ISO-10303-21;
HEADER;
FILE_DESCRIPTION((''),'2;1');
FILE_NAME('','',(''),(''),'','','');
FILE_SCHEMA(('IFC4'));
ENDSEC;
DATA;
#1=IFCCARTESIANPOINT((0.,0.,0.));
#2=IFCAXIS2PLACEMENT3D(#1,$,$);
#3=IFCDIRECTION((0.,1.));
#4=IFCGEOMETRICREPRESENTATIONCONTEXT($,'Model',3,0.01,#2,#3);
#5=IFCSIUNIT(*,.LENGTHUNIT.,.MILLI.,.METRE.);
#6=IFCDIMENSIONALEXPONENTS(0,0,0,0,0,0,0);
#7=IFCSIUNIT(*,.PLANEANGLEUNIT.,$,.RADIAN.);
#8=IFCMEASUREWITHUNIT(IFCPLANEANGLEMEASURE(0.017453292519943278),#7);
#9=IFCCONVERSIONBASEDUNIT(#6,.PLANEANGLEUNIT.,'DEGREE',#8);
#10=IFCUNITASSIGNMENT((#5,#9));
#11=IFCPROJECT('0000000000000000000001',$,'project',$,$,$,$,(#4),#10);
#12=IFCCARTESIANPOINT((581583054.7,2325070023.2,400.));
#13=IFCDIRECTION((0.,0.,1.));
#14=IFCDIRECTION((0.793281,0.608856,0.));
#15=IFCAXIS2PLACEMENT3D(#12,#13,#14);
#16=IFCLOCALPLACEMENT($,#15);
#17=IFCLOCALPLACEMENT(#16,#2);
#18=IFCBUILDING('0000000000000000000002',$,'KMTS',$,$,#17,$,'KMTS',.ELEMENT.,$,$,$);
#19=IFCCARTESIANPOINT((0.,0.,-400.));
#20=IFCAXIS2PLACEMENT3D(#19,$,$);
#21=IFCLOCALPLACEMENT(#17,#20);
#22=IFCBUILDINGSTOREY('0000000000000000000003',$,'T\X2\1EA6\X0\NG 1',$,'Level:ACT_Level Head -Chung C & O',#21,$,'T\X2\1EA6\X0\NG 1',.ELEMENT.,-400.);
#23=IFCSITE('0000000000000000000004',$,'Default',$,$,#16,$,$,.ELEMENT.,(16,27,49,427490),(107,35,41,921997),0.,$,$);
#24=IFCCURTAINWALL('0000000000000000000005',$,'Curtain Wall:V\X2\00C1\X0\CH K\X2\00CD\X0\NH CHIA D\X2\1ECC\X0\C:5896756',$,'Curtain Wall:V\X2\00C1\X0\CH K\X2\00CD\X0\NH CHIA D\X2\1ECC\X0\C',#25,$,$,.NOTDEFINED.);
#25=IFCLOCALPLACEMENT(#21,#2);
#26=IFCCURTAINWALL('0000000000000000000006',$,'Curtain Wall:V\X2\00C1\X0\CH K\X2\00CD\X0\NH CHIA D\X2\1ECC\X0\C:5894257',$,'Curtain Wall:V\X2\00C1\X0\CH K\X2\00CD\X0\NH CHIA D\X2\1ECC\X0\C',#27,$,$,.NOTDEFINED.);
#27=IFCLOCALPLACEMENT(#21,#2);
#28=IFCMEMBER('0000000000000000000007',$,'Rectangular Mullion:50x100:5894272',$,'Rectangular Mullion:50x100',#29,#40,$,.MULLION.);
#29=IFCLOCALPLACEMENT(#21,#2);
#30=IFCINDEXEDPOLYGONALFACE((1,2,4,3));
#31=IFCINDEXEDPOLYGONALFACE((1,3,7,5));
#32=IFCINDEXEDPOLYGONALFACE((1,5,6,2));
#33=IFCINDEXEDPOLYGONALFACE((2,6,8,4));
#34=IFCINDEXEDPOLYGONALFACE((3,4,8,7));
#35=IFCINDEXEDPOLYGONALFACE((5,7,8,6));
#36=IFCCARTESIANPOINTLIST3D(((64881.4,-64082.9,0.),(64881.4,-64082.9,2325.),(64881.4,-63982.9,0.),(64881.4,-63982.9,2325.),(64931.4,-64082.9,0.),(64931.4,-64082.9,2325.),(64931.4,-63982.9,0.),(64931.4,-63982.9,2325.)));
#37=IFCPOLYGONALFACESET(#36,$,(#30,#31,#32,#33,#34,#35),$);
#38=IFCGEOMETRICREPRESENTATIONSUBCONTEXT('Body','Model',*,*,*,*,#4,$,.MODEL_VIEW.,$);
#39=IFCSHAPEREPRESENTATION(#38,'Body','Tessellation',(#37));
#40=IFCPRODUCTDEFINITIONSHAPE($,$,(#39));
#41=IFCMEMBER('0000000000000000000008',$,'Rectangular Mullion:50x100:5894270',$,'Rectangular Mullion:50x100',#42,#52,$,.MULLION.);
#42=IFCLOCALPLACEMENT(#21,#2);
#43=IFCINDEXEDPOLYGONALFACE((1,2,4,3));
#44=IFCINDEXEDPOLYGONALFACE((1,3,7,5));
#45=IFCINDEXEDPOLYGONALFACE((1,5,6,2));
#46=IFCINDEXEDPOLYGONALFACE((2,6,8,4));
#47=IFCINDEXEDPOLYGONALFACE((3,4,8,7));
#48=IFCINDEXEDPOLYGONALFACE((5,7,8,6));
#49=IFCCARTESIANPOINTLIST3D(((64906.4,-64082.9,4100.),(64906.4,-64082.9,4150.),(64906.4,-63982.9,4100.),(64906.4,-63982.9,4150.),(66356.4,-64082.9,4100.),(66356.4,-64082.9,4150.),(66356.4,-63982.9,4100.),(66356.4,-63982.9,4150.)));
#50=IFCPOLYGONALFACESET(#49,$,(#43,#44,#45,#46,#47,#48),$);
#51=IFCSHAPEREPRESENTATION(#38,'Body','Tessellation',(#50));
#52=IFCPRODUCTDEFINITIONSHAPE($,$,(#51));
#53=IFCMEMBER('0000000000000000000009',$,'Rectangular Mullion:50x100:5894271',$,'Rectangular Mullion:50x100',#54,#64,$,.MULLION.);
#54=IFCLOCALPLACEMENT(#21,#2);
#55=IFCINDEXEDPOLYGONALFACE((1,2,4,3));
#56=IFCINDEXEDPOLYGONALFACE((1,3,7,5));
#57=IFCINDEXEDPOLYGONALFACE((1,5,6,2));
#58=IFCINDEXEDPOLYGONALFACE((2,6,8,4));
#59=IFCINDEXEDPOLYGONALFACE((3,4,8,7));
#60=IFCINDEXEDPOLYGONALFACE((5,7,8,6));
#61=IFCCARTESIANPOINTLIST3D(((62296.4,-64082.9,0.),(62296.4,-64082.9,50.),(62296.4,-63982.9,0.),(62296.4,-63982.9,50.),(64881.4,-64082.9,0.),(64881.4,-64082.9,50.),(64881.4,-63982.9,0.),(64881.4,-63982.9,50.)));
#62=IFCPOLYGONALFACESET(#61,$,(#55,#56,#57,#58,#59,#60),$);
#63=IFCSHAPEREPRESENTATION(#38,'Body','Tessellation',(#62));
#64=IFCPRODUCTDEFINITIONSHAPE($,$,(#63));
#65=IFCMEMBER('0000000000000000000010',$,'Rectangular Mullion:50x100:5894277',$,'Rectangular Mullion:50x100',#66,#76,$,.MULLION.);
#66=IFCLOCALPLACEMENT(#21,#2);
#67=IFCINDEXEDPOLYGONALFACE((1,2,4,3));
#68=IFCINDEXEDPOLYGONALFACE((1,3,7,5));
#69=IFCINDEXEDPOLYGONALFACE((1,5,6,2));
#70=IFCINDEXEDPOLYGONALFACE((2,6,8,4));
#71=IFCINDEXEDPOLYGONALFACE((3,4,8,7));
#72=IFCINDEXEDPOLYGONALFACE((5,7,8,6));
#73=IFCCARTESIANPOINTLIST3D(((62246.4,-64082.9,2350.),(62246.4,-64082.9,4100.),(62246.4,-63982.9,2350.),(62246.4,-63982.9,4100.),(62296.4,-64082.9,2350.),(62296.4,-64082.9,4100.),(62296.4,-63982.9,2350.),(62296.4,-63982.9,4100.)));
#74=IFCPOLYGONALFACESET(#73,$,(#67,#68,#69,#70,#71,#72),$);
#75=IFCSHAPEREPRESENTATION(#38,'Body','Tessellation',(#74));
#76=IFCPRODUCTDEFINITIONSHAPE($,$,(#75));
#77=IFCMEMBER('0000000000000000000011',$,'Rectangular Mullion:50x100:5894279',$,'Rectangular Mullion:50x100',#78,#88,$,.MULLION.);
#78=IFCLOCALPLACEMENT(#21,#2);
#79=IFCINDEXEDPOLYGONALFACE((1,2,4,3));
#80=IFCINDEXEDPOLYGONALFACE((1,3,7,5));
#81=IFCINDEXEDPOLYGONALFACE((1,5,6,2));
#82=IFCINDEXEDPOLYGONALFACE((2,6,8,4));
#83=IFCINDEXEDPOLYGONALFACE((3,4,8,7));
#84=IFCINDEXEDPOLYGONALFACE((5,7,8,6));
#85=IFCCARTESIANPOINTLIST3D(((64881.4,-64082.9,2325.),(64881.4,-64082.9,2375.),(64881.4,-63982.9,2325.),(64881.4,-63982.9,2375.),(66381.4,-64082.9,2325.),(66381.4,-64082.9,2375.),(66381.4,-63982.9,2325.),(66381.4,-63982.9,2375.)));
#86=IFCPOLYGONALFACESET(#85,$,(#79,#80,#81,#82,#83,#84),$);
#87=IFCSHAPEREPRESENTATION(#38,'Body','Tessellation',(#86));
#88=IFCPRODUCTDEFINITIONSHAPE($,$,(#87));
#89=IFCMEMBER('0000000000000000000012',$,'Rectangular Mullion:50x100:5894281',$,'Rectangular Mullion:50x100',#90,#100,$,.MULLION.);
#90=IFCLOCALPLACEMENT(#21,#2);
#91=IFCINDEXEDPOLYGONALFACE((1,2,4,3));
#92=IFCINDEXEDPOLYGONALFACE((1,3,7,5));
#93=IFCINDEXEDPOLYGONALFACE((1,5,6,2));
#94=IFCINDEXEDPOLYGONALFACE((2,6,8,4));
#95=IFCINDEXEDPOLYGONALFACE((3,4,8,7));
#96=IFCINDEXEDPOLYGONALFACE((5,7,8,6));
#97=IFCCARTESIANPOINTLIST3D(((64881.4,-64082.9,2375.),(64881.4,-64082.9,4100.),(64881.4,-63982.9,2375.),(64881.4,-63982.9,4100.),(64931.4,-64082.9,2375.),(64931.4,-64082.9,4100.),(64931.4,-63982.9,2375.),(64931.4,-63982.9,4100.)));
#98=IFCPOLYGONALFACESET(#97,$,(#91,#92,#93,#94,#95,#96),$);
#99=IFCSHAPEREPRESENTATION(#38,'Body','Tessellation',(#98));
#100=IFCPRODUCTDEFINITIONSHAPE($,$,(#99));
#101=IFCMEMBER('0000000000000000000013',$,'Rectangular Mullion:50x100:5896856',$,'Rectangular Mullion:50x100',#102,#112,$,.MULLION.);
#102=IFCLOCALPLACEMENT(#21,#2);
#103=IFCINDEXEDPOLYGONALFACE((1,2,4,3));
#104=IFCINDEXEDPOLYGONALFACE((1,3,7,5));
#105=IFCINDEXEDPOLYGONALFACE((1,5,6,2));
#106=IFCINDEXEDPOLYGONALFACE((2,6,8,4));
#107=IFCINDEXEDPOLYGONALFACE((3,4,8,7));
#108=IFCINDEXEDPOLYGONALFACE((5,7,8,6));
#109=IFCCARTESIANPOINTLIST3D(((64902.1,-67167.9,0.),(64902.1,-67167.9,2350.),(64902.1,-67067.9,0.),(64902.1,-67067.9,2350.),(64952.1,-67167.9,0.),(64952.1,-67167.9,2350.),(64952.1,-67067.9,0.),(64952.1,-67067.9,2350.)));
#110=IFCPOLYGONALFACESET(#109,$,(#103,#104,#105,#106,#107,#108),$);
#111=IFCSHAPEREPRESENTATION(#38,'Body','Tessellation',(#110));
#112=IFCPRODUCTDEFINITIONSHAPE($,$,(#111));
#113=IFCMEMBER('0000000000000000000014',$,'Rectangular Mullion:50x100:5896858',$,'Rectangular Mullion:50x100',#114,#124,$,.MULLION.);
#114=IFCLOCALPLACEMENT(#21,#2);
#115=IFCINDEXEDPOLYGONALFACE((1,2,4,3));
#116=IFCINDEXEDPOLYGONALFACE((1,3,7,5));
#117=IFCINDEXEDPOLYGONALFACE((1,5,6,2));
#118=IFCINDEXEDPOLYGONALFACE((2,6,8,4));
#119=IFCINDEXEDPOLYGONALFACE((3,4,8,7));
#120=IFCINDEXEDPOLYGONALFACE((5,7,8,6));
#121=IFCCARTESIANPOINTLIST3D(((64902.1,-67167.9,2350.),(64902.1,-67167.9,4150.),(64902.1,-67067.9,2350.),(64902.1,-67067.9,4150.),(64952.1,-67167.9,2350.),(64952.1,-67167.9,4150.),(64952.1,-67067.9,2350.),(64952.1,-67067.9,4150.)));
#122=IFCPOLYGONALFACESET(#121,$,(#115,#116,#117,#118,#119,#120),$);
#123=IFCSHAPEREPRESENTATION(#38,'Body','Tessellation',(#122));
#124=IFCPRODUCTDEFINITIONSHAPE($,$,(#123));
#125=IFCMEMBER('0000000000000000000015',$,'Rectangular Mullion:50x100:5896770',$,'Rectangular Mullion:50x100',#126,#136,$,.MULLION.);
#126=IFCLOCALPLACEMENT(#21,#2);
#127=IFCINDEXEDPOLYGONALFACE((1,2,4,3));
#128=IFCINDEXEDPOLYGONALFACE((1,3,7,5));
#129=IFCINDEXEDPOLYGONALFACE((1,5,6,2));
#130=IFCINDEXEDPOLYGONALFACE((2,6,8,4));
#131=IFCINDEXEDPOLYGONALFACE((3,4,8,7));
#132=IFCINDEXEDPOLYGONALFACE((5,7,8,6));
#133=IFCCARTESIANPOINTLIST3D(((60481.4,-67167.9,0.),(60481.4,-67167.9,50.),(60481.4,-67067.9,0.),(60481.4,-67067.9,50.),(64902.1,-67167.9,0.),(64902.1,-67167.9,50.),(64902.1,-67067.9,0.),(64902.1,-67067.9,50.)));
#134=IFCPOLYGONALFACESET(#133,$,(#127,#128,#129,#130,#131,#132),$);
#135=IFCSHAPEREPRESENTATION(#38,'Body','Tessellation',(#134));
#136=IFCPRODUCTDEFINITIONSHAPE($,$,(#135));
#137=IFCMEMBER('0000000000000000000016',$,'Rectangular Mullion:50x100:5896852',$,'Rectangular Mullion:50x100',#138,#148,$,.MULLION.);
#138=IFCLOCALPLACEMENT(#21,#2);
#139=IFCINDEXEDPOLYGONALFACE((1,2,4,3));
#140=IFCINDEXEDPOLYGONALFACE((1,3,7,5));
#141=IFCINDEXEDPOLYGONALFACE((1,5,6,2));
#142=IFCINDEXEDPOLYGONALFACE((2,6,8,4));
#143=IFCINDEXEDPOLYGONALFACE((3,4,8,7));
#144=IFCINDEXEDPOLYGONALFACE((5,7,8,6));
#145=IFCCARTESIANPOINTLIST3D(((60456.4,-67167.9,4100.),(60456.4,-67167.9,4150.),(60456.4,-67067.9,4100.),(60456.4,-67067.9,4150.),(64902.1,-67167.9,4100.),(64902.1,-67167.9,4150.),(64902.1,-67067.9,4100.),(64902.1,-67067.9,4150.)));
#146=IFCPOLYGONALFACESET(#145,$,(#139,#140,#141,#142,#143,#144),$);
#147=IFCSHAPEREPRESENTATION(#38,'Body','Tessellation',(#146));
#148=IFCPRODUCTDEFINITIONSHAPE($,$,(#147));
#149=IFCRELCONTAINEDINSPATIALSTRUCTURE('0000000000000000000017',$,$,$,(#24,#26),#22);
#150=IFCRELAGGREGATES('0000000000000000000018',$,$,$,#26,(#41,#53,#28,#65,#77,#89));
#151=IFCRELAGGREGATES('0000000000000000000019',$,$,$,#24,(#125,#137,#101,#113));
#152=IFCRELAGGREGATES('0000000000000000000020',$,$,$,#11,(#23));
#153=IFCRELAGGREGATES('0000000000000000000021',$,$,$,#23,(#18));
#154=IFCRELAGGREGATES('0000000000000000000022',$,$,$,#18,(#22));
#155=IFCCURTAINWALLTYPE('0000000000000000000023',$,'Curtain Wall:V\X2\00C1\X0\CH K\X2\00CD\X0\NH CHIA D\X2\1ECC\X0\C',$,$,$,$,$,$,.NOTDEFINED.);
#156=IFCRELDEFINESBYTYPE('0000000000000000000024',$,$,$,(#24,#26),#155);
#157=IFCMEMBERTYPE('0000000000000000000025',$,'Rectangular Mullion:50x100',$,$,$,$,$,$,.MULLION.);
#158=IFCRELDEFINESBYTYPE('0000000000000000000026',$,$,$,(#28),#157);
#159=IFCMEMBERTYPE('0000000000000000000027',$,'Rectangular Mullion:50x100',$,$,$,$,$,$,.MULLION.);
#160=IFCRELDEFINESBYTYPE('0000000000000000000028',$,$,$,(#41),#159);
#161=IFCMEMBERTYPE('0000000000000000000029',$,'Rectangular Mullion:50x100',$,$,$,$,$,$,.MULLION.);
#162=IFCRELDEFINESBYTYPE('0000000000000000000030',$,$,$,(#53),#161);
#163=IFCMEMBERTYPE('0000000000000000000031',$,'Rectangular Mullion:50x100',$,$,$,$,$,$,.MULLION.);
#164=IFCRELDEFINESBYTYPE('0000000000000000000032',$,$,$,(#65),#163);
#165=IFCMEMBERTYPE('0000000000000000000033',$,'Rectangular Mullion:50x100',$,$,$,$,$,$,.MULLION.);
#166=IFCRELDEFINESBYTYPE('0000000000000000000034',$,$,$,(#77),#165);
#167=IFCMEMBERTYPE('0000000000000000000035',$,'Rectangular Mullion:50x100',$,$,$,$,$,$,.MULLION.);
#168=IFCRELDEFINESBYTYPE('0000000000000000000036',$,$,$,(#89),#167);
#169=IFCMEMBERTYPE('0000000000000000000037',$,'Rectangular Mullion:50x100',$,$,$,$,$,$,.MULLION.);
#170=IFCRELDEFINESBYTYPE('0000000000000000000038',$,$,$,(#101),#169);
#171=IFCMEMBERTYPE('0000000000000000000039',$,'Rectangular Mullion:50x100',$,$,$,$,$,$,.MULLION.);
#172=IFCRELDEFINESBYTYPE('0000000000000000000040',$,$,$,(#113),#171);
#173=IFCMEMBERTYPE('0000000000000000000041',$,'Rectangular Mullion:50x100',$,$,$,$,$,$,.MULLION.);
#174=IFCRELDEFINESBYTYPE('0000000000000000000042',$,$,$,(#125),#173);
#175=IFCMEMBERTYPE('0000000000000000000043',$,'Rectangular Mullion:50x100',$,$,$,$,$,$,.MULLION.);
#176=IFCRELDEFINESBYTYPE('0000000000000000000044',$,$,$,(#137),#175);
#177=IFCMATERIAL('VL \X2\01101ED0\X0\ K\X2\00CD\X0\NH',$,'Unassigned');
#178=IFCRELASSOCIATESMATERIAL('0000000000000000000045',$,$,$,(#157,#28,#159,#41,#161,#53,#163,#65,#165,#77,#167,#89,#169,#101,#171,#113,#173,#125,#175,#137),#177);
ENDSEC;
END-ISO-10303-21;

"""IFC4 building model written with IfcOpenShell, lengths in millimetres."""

from ifc_helpers import new_model, entity, si_unit, converted_unit, direction, frame, origin, place, context, subcontext, project, spatial, indexed_curve, outline, extrude, source, transform, mapped, material, type_object, type_shapes, element, aggregate, save


model = new_model("IFC4")

# Units and contexts
model_context = context("Model", 3, precision=0.01, world=origin(), true_north=direction((0.0, 1.0)))
body_context = subcontext(model_context, "Body", "Model", "MODEL_VIEW")
ifc_project = project(units=[si_unit("LENGTHUNIT", "METRE", prefix="MILLI"), converted_unit("PLANEANGLEUNIT", "DEGREE", entity("IfcPlaneAngleMeasure", 0.017453292519943278), si_unit("PLANEANGLEUNIT", "RADIAN"), dimensions=[0, 0, 0, 0, 0, 0, 0])], contexts=[model_context])

# Site, building, storey
site_placement = place(None, frame((581583054.7, 2325070023.2, 400.0), z_axis=(0.0, 0.0, 1.0), x_axis=(0.793281, 0.608856, 0.0)))
site = spatial("IfcSite", under=ifc_project, at=site_placement, Name="Default", CompositionType="ELEMENT", RefLatitude=(16, 27, 49, 427490), RefLongitude=(107, 35, 41, 921997), RefElevation=0.0)
building_placement = place(site_placement, origin())
building = spatial("IfcBuilding", under=site, at=building_placement, Name="KMTS", LongName="KMTS", CompositionType="ELEMENT")
storey_placement = place(building_placement, frame((0.0, 0.0, -400.0)))
storey = spatial("IfcBuildingStorey", under=building, at=storey_placement, Name="TẦNG 1", ObjectType="Level:ACT_Level Head -Chung C & O", LongName="TẦNG 1", CompositionType="ELEMENT", Elevation=-400.0)

# Curtain walls, members
curtain_wall_type = type_object("IfcCurtainWallType", Name="Curtain Wall:VÁCH KÍNH CHIA DỌC", PredefinedType="NOTDEFINED")
curtain_wall_1_placement = place(storey_placement, frame((0.0, 0.0, 400.0)))
curtain_wall_1 = element("IfcCurtainWall", 1, at=curtain_wall_1_placement, inside=storey, type_object=curtain_wall_type, Name="Curtain Wall:VÁCH KÍNH CHIA DỌC:5896756", ObjectType="Curtain Wall:VÁCH KÍNH CHIA DỌC", PredefinedType="NOTDEFINED")
ifc_material_1 = material(Name="VL ĐỐ KÍNH", Category="Unassigned")
curtain_wall_2_placement = place(storey_placement, frame((0.0, 0.0, 400.0)))
curtain_wall_2 = element("IfcCurtainWall", 2, at=curtain_wall_2_placement, inside=storey, type_object=curtain_wall_type, Name="Curtain Wall:VÁCH KÍNH CHIA DỌC:5894257", ObjectType="Curtain Wall:VÁCH KÍNH CHIA DỌC", PredefinedType="NOTDEFINED")
member_type_1 = type_object("IfcMemberType", Name="Rectangular Mullion:50x100", PredefinedType="MULLION", material=ifc_material_1)
shared_shape_1 = source(origin(), body_context, "Body", "SweptSolid", [
    extrude(outline(indexed_curve([(-25.0, -50.0), (25.0, -50.0), (25.0, 50.0), (-25.0, 50.0), (-25.0, -50.0)], self_intersect=False)), frame((0.0, 0.0, -2325.0), z_axis=(0.0, 0.0, 1.0), x_axis=(-1.0, 0.0, 0.0)), (0.0, 0.0, 1.0), 2325.0),
])
type_shapes(member_type_1, [shared_shape_1])
member_1_placement = place(curtain_wall_2_placement, frame((64906.4, -64032.9, -400.0), z_axis=(0.0, 0.0, -1.0), x_axis=(-1.0, 0.0, 0.0)))
member_1 = element("IfcMember", 3, at=member_1_placement, type_object=member_type_1, material=ifc_material_1, Name="Rectangular Mullion:50x100:5894272", ObjectType="Rectangular Mullion:50x100", PredefinedType="MULLION", context=body_context, shape_type="MappedRepresentation", body=[
    mapped(shared_shape_1, transform((0.0, 0.0, 0.0), scale=1.0)),
])
member_type_2 = type_object("IfcMemberType", Name="Rectangular Mullion:50x100", PredefinedType="MULLION", material=ifc_material_1)
shared_shape_2 = source(origin(), body_context, "Body", "SweptSolid", [
    extrude(outline(indexed_curve([(-25.0, -50.0), (25.0, -50.0), (25.0, 50.0), (-25.0, 50.0), (-25.0, -50.0)], self_intersect=False)), frame((-25.0, 0.0, -1450.0), z_axis=(0.0, 0.0, 1.0), x_axis=(-1.0, 0.0, 0.0)), (0.0, 0.0, 1.0), 1450.0),
])
type_shapes(member_type_2, [shared_shape_2])
member_2_placement = place(curtain_wall_2_placement, frame((64906.4, -64032.9, 3750.0), z_axis=(-1.0, 0.0, 0.0), x_axis=(0.0, 0.0, 1.0)))
member_2 = element("IfcMember", 4, at=member_2_placement, type_object=member_type_2, material=ifc_material_1, Name="Rectangular Mullion:50x100:5894270", ObjectType="Rectangular Mullion:50x100", PredefinedType="MULLION", context=body_context, shape_type="MappedRepresentation", body=[
    mapped(shared_shape_2, transform((0.0, 0.0, 0.0), scale=1.0)),
])
member_type_3 = type_object("IfcMemberType", Name="Rectangular Mullion:50x100", PredefinedType="MULLION", material=ifc_material_1)
shared_shape_3 = source(origin(), body_context, "Body", "SweptSolid", [
    extrude(outline(indexed_curve([(-25.0, -50.0), (25.0, -50.0), (25.0, 50.0), (-25.0, 50.0), (-25.0, -50.0)], self_intersect=False)), frame((-25.0, 0.0, -2585.0), z_axis=(0.0, 0.0, 1.0), x_axis=(-1.0, 0.0, 0.0)), (0.0, 0.0, 1.0), 2585.0),
])
type_shapes(member_type_3, [shared_shape_3])
member_3_placement = place(curtain_wall_2_placement, frame((64881.4, -64032.9, -400.0), z_axis=(1.0, 0.0, 0.0), x_axis=(0.0, 0.0, -1.0)))
member_3 = element("IfcMember", 5, at=member_3_placement, type_object=member_type_3, material=ifc_material_1, Name="Rectangular Mullion:50x100:5894271", ObjectType="Rectangular Mullion:50x100", PredefinedType="MULLION", context=body_context, shape_type="MappedRepresentation", body=[
    mapped(shared_shape_3, transform((0.0, 0.0, 0.0), scale=1.0)),
])
member_type_4 = type_object("IfcMemberType", Name="Rectangular Mullion:50x100", PredefinedType="MULLION", material=ifc_material_1)
shared_shape_4 = source(origin(), body_context, "Body", "SweptSolid", [
    extrude(outline(indexed_curve([(-25.0, -50.0), (25.0, -50.0), (25.0, 50.0), (-25.0, 50.0), (-25.0, -50.0)], self_intersect=False)), frame((-25.0, 0.0, -1750.0), z_axis=(0.0, 0.0, 1.0), x_axis=(-1.0, 0.0, 0.0)), (0.0, 0.0, 1.0), 1750.0),
])
type_shapes(member_type_4, [shared_shape_4])
member_4_placement = place(curtain_wall_2_placement, frame((62246.4, -64032.9, 1950.0), z_axis=(0.0, 0.0, -1.0), x_axis=(-1.0, 0.0, 0.0)))
member_4 = element("IfcMember", 6, at=member_4_placement, type_object=member_type_4, material=ifc_material_1, Name="Rectangular Mullion:50x100:5894277", ObjectType="Rectangular Mullion:50x100", PredefinedType="MULLION", context=body_context, shape_type="MappedRepresentation", body=[
    mapped(shared_shape_4, transform((0.0, 0.0, 0.0), scale=1.0)),
])
member_type_5 = type_object("IfcMemberType", Name="Rectangular Mullion:50x100", PredefinedType="MULLION", material=ifc_material_1)
shared_shape_5 = source(origin(), body_context, "Body", "SweptSolid", [
    extrude(outline(indexed_curve([(-25.0, -50.0), (25.0, -50.0), (25.0, 50.0), (-25.0, 50.0), (-25.0, -50.0)], self_intersect=False)), frame((0.0, 0.0, -1500.0), z_axis=(0.0, 0.0, 1.0), x_axis=(-1.0, 0.0, 0.0)), (0.0, 0.0, 1.0), 1500.0),
])
type_shapes(member_type_5, [shared_shape_5])
member_5_placement = place(curtain_wall_2_placement, frame((64881.4, -64032.9, 1950.0), z_axis=(-1.0, 0.0, 0.0), x_axis=(0.0, 0.0, 1.0)))
member_5 = element("IfcMember", 7, at=member_5_placement, type_object=member_type_5, material=ifc_material_1, Name="Rectangular Mullion:50x100:5894279", ObjectType="Rectangular Mullion:50x100", PredefinedType="MULLION", context=body_context, shape_type="MappedRepresentation", body=[
    mapped(shared_shape_5, transform((0.0, 0.0, 0.0), scale=1.0)),
])
member_type_6 = type_object("IfcMemberType", Name="Rectangular Mullion:50x100", PredefinedType="MULLION", material=ifc_material_1)
shared_shape_6 = source(origin(), body_context, "Body", "SweptSolid", [
    extrude(outline(indexed_curve([(-25.0, -50.0), (25.0, -50.0), (25.0, 50.0), (-25.0, 50.0), (-25.0, -50.0)], self_intersect=False)), frame((0.0, 0.0, -1725.0), z_axis=(0.0, 0.0, 1.0), x_axis=(-1.0, 0.0, 0.0)), (0.0, 0.0, 1.0), 1725.0),
])
type_shapes(member_type_6, [shared_shape_6])
member_6_placement = place(curtain_wall_2_placement, frame((64906.4, -64032.9, 1975.0), z_axis=(0.0, 0.0, -1.0), x_axis=(-1.0, 0.0, 0.0)))
member_6 = element("IfcMember", 8, at=member_6_placement, type_object=member_type_6, material=ifc_material_1, Name="Rectangular Mullion:50x100:5894281", ObjectType="Rectangular Mullion:50x100", PredefinedType="MULLION", context=body_context, shape_type="MappedRepresentation", body=[
    mapped(shared_shape_6, transform((0.0, 0.0, 0.0), scale=1.0)),
])

# Members
member_type_7 = type_object("IfcMemberType", Name="Rectangular Mullion:50x100", PredefinedType="MULLION", material=ifc_material_1)
shared_shape_7 = source(origin(), body_context, "Body", "SweptSolid", [
    extrude(outline(indexed_curve([(-25.0, -50.0), (25.0, -50.0), (25.0, 50.0), (-25.0, 50.0), (-25.0, -50.0)], self_intersect=False)), frame((0.0, 0.0, -2350.0), z_axis=(0.0, 0.0, 1.0), x_axis=(-1.0, 0.0, 0.0)), (0.0, 0.0, 1.0), 2350.0),
])
type_shapes(member_type_7, [shared_shape_7])
member_7_placement = place(curtain_wall_1_placement, frame((64927.1, -67117.9, -400.0), z_axis=(0.0, 0.0, -1.0), x_axis=(1.0, 0.0, 0.0)))
member_7 = element("IfcMember", 9, at=member_7_placement, type_object=member_type_7, material=ifc_material_1, Name="Rectangular Mullion:50x100:5896856", ObjectType="Rectangular Mullion:50x100", PredefinedType="MULLION", context=body_context, shape_type="MappedRepresentation", body=[
    mapped(shared_shape_7, transform((0.0, 0.0, 0.0), scale=1.0)),
])
member_type_8 = type_object("IfcMemberType", Name="Rectangular Mullion:50x100", PredefinedType="MULLION", material=ifc_material_1)
shared_shape_8 = source(origin(), body_context, "Body", "SweptSolid", [
    extrude(outline(indexed_curve([(-25.0, -50.0), (25.0, -50.0), (25.0, 50.0), (-25.0, 50.0), (-25.0, -50.0)], self_intersect=False)), frame((0.0, 0.0, -1800.0), z_axis=(0.0, 0.0, 1.0), x_axis=(-1.0, 0.0, 0.0)), (0.0, 0.0, 1.0), 1800.0),
])
type_shapes(member_type_8, [shared_shape_8])
member_8_placement = place(curtain_wall_1_placement, frame((64927.1, -67117.9, 1950.0), z_axis=(0.0, 0.0, -1.0), x_axis=(1.0, 0.0, 0.0)))
member_8 = element("IfcMember", 10, at=member_8_placement, type_object=member_type_8, material=ifc_material_1, Name="Rectangular Mullion:50x100:5896858", ObjectType="Rectangular Mullion:50x100", PredefinedType="MULLION", context=body_context, shape_type="MappedRepresentation", body=[
    mapped(shared_shape_8, transform((0.0, 0.0, 0.0), scale=1.0)),
])
member_type_9 = type_object("IfcMemberType", Name="Rectangular Mullion:50x100", PredefinedType="MULLION", material=ifc_material_1)
shared_shape_9 = source(origin(), body_context, "Body", "SweptSolid", [
    extrude(outline(indexed_curve([(-25.0, -50.0), (25.0, -50.0), (25.0, 50.0), (-25.0, 50.0), (-25.0, -50.0)], self_intersect=False)), frame((-25.0, 0.0, -4420.7), z_axis=(0.0, 0.0, 1.0), x_axis=(-1.0, 0.0, 0.0)), (0.0, 0.0, 1.0), 4420.7),
])
type_shapes(member_type_9, [shared_shape_9])
member_9_placement = place(curtain_wall_1_placement, frame((60481.4, -67117.9, -400.0), z_axis=(-1.0, 0.0, 0.0), x_axis=(0.0, 0.0, -1.0)))
member_9 = element("IfcMember", 11, at=member_9_placement, type_object=member_type_9, material=ifc_material_1, Name="Rectangular Mullion:50x100:5896770", ObjectType="Rectangular Mullion:50x100", PredefinedType="MULLION", context=body_context, shape_type="MappedRepresentation", body=[
    mapped(shared_shape_9, transform((0.0, 0.0, 0.0), scale=1.0)),
])
member_type_10 = type_object("IfcMemberType", Name="Rectangular Mullion:50x100", PredefinedType="MULLION", material=ifc_material_1)
shared_shape_10 = source(origin(), body_context, "Body", "SweptSolid", [
    extrude(outline(indexed_curve([(-25.0, -50.0), (25.0, -50.0), (25.0, 50.0), (-25.0, 50.0), (-25.0, -50.0)], self_intersect=False)), frame((-25.0, 0.0, -4445.7), z_axis=(0.0, 0.0, 1.0), x_axis=(-1.0, 0.0, 0.0)), (0.0, 0.0, 1.0), 4445.7),
])
type_shapes(member_type_10, [shared_shape_10])
member_10_placement = place(curtain_wall_1_placement, frame((64902.1, -67117.9, 3750.0), z_axis=(1.0, 0.0, 0.0), x_axis=(0.0, 0.0, 1.0)))
member_10 = element("IfcMember", 12, at=member_10_placement, type_object=member_type_10, material=ifc_material_1, Name="Rectangular Mullion:50x100:5896852", ObjectType="Rectangular Mullion:50x100", PredefinedType="MULLION", context=body_context, shape_type="MappedRepresentation", body=[
    mapped(shared_shape_10, transform((0.0, 0.0, 0.0), scale=1.0)),
])

aggregate(curtain_wall_2, [member_2, member_3, member_1, member_4, member_5, member_6])

aggregate(curtain_wall_1, [member_9, member_10, member_7, member_8])

save(model, "model.ifc")
